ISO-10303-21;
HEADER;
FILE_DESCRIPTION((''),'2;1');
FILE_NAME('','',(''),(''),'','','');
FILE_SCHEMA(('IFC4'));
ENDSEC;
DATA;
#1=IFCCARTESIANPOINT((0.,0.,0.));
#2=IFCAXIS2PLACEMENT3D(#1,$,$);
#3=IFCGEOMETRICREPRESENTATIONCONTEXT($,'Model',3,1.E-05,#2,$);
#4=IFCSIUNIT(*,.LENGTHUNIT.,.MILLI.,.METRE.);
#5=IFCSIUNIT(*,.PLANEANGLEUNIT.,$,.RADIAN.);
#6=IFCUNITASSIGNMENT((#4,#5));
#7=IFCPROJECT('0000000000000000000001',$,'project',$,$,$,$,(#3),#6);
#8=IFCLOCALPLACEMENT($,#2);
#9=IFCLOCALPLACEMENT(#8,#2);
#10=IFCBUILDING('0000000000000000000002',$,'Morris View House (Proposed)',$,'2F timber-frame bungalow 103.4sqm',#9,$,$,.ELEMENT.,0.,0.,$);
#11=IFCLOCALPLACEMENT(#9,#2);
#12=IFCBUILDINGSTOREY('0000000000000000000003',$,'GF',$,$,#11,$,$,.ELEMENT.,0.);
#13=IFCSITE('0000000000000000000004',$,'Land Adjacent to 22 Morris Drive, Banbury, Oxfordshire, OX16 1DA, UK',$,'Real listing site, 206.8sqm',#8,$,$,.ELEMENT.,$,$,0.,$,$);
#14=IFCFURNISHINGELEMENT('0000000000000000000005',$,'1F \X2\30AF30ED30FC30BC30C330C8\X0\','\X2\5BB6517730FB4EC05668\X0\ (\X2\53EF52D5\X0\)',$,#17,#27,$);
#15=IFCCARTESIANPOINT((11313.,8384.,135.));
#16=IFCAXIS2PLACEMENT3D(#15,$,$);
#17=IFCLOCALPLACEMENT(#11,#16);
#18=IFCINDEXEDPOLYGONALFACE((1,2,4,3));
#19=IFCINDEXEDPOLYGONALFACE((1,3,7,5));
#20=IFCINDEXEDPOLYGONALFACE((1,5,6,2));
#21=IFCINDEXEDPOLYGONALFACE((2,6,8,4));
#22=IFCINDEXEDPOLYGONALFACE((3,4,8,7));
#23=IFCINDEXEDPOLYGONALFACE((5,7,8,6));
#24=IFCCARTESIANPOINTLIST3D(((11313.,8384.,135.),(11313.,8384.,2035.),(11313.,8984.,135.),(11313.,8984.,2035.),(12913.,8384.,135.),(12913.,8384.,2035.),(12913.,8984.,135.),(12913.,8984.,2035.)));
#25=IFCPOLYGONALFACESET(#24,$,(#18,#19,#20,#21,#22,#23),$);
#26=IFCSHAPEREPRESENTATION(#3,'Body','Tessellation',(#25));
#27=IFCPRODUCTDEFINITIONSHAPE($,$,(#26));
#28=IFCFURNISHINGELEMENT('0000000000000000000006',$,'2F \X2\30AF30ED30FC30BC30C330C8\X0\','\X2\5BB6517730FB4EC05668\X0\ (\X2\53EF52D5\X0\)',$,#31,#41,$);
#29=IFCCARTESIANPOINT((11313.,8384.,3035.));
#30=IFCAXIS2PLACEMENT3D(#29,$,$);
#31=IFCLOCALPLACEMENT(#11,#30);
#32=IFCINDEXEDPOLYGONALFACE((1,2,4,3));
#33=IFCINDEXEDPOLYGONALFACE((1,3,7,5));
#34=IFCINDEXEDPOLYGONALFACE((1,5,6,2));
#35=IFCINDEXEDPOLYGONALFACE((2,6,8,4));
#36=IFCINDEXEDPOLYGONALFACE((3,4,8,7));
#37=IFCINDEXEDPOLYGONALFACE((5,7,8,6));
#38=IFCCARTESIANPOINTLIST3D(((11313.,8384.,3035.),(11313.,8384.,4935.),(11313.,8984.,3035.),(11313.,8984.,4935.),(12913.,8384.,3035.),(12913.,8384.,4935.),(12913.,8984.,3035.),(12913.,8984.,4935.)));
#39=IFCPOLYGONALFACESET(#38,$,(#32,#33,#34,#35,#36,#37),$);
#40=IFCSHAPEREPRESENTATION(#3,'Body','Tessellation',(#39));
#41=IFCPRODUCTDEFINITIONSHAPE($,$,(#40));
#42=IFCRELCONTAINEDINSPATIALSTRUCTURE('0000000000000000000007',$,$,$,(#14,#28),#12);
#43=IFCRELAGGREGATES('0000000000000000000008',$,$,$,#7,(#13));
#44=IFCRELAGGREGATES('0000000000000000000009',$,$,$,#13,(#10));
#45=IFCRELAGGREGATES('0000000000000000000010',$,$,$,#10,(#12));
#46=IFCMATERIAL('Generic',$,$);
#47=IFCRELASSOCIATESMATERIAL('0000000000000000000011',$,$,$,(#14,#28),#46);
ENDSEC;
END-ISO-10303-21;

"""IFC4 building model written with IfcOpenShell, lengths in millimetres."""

from ifc_helpers import new_model, si_unit, frame, frame_2d, origin, place, context, project, spatial, rectangle, extrude, material, element, save


model = new_model("IFC4")

# Units and contexts
model_context = context("Model", 3, precision=1e-05, world=origin())
ifc_project = project(units=[si_unit("LENGTHUNIT", "METRE", prefix="MILLI"), si_unit("PLANEANGLEUNIT", "RADIAN")], contexts=[model_context])

# Site, building, storey
site_placement = place(None, origin())
site = spatial("IfcSite", under=ifc_project, at=site_placement, Name="Land Adjacent to 22 Morris Drive, Banbury, Oxfordshire, OX16 1DA, UK", ObjectType="Real listing site, 206.8sqm", CompositionType="ELEMENT", RefElevation=0.0)
building_placement = place(site_placement, origin())
building = spatial("IfcBuilding", under=site, at=building_placement, Name="Morris View House (Proposed)", ObjectType="2F timber-frame bungalow 103.4sqm", CompositionType="ELEMENT", ElevationOfRefHeight=0.0, ElevationOfTerrain=0.0)
storey_placement = place(building_placement, origin())
storey = spatial("IfcBuildingStorey", under=building, at=storey_placement, Name="GF", CompositionType="ELEMENT", Elevation=0.0)

# Shared definitions
ifc_material_1 = material(Name="Generic")

# Furnishing elements
furnishing_1_placement = place(storey_placement, frame((11313.0, 8384.0, 135.0)))
element("IfcFurnishingElement", 1, at=furnishing_1_placement, inside=storey, material=ifc_material_1, Name="1F クローゼット", Description="家具・什器 (可動)", context=model_context, shape_type="SweptSolid", body=[
    extrude(rectangle(XDim=1600.0, YDim=600.0, at=frame_2d((800.0, 300.0))), frame((11313.0, 8384.0, 135.0)), (0.0, 0.0, 1.0), 1900.0),
])
furnishing_2_placement = place(storey_placement, frame((11313.0, 8384.0, 3035.0)))
element("IfcFurnishingElement", 2, at=furnishing_2_placement, inside=storey, material=ifc_material_1, Name="2F クローゼット", Description="家具・什器 (可動)", context=model_context, shape_type="SweptSolid", body=[
    extrude(rectangle(XDim=1600.0, YDim=600.0, at=frame_2d((800.0, 300.0))), frame((11313.0, 8384.0, 3035.0)), (0.0, 0.0, 1.0), 1900.0),
])

save(model, "model.ifc")
